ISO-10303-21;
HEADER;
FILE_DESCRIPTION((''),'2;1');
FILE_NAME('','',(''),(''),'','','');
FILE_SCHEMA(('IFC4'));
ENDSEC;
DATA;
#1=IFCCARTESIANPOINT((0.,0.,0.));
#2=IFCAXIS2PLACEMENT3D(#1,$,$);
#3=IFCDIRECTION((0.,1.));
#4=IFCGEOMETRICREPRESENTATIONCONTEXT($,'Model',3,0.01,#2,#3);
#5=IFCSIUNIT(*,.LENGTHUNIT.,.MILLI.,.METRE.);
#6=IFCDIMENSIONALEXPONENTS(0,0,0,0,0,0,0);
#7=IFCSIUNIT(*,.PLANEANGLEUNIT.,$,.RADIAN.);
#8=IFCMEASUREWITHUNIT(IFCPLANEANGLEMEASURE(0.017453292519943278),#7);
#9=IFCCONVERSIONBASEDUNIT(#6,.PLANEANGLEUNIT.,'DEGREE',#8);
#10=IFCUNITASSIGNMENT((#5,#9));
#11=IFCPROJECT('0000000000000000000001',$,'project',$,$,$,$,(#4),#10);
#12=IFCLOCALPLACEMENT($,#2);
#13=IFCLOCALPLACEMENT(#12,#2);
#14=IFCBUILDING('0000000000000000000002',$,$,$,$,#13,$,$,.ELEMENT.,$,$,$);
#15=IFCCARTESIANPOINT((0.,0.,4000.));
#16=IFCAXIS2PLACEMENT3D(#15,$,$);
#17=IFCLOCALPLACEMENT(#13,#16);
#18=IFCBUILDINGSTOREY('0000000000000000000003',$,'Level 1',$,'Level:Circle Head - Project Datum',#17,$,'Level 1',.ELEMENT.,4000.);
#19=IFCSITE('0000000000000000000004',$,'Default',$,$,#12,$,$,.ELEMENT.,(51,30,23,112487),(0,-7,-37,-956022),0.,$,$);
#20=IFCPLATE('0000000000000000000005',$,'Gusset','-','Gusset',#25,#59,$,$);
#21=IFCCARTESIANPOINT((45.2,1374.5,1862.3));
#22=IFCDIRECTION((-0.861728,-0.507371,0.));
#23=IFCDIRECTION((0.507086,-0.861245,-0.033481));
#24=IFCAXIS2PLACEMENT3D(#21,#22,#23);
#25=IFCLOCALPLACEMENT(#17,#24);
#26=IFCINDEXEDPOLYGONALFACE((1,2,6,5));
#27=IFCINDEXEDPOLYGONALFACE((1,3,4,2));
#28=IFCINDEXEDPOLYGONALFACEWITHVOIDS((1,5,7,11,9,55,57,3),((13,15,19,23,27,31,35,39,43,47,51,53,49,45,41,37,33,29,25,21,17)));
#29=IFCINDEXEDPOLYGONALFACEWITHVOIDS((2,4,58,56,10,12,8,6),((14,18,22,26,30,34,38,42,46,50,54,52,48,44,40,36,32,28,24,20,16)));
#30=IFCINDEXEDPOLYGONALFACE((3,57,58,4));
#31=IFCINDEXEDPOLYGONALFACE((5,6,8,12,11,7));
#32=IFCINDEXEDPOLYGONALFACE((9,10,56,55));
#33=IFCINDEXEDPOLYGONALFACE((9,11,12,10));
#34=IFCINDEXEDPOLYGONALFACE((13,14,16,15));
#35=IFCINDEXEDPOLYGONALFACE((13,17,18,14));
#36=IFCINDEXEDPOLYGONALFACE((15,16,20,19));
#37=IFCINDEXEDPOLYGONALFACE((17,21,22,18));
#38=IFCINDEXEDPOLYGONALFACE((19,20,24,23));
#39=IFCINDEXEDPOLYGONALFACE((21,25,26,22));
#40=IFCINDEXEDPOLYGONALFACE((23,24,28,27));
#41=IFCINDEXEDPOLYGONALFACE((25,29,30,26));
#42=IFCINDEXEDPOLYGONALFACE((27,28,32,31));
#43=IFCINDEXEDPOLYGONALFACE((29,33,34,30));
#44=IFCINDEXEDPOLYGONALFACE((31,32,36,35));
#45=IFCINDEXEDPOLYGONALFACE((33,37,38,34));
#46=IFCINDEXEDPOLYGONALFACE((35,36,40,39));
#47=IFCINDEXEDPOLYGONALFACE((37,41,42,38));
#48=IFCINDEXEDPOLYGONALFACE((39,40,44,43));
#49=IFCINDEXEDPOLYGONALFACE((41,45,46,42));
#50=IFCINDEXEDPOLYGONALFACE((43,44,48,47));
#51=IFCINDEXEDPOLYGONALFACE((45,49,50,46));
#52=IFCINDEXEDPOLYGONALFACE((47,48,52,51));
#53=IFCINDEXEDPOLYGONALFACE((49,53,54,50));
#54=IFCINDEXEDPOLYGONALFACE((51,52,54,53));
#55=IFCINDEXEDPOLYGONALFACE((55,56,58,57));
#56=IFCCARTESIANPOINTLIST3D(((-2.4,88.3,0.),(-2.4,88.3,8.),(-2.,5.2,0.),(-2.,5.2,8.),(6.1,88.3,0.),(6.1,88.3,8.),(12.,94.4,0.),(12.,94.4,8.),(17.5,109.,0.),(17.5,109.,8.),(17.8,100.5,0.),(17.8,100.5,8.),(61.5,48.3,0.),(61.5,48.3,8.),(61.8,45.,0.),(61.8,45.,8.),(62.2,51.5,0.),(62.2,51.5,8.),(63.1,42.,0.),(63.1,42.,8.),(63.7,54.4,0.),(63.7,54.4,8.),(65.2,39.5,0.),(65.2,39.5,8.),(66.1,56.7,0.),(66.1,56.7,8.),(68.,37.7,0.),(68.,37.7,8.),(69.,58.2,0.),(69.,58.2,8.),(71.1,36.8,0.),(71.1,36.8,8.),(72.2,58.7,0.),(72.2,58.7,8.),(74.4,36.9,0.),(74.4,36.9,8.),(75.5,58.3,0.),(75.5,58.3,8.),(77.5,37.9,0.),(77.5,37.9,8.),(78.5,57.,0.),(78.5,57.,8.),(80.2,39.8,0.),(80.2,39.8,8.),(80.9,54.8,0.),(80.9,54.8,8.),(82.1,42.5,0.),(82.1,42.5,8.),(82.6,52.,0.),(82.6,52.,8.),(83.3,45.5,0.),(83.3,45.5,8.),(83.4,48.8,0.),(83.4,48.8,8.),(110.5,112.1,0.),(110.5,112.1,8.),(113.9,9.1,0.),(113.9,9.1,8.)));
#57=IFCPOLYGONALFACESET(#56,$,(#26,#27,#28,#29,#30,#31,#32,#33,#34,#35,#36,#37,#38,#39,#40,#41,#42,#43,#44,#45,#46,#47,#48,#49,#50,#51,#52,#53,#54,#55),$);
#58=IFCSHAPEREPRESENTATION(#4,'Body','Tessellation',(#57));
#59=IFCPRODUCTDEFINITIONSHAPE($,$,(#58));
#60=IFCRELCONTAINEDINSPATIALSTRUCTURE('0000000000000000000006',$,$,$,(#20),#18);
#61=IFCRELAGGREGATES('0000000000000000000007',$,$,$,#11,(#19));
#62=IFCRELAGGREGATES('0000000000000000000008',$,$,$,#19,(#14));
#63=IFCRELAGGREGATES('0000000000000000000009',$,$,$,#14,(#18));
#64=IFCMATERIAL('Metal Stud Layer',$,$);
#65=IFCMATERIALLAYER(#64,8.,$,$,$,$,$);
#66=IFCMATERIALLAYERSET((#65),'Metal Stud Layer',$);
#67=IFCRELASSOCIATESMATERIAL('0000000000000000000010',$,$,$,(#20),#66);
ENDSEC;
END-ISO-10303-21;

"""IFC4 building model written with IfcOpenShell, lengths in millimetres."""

from ifc_helpers import new_model, entity, si_unit, converted_unit, point, direction, frame, frame_2d, origin, origin_with_axes, origin_2d_with_axis, place, context, project, spatial, polyline, circle_curve, line_curve, trimmed, segment, composite_curve, circle, outline, extrude, material, layer, layer_set, element, save


model = new_model("IFC4")

# Units and contexts
model_context = context("Model", 3, precision=0.01, world=origin(), true_north=direction((0.0, 1.0)))
ifc_project = project(units=[si_unit("LENGTHUNIT", "METRE", prefix="MILLI"), converted_unit("PLANEANGLEUNIT", "DEGREE", entity("IfcPlaneAngleMeasure", 0.017453292519943278), si_unit("PLANEANGLEUNIT", "RADIAN"), dimensions=[0, 0, 0, 0, 0, 0, 0])], contexts=[model_context])

# Site, building, storey
site_placement = place(None, origin())
site = spatial("IfcSite", under=ifc_project, at=site_placement, Name="Default", CompositionType="ELEMENT", RefLatitude=(51, 30, 23, 112487), RefLongitude=(0, -7, -37, -956022), RefElevation=0.0)
building_placement = place(site_placement, origin())
building = spatial("IfcBuilding", under=site, at=building_placement, CompositionType="ELEMENT")
storey_placement = place(building_placement, frame((0.0, 0.0, 4000.0)))
storey = spatial("IfcBuildingStorey", under=building, at=storey_placement, Name="Level 1", ObjectType="Level:Circle Head - Project Datum", LongName="Level 1", CompositionType="ELEMENT", Elevation=4000.0)

# Plate, openings
ifc_material_1 = material(Name="Metal Stud Layer")
ifc_layer_1 = layer(ifc_material_1, 8.0)
ifc_layer_set_1 = layer_set([ifc_layer_1], Name="Metal Stud Layer")
plate_1_placement = place(storey_placement, frame((45.2, 1374.5, 1862.3), z_axis=(-0.861728, -0.507371, 0.0), x_axis=(0.507086, -0.861245, -0.033481)))
plate_1 = element("IfcPlate", 1, at=plate_1_placement, inside=storey, material=ifc_layer_set_1, Name="Gusset", Description="-", ObjectType="Gusset", context=model_context, shape_type="SweptSolid", body=[
    extrude(outline(polyline([(-2.0, 5.2), (113.9, 9.1), (110.5, 112.1), (17.5, 109.0), (17.8, 100.5), (6.1, 88.3), (-2.4, 88.3), (-2.0, 5.2)])), origin_with_axes(), (0.0, 0.0, 1.0), 8.0),
])
opening_1_placement = place(plate_1_placement, origin_with_axes())
element("IfcOpeningElement", 2, at=opening_1_placement, cuts=plate_1, ObjectType="Opening", context=model_context, shape_type="SweptSolid", body=[
    extrude(outline(composite_curve([segment(trimmed(line_curve((17.8, 100.5), (-0.693597, -0.720363), 8.455359), [point((17.8, 100.5))], [point((12.0, 94.4))], True, "CARTESIAN"), True, "CONTINUOUS"), segment(trimmed(circle_curve(frame_2d((-2.4, 108.3), x_axis=(1.0, 0.0)), 20.0), [point((12.0, 94.4))], [point((17.5, 109.0))], True, "CARTESIAN"), True, "CONTINUOUS"), segment(trimmed(line_curve((17.5, 109.0), (0.033481, -0.999439), 8.455359), [point((17.5, 109.0))], [point((17.8, 100.5))], True, "CARTESIAN"), True, "CONTINUOUS")], self_intersect="UNKNOWN")), origin(), (0.0, 0.0, 1.0), 8.0),
])
opening_2_placement = place(plate_1_placement, origin_with_axes())
element("IfcOpeningElement", 3, at=opening_2_placement, cuts=plate_1, ObjectType="Opening", context=model_context, shape_type="SweptSolid", body=[
    extrude(outline(composite_curve([segment(trimmed(line_curve((6.1, 88.3), (-0.99999, -0.004369), 8.455359), [point((6.1, 88.3))], [point((-2.4, 88.3))], True, "CARTESIAN"), True, "CONTINUOUS"), segment(trimmed(circle_curve(frame_2d((-2.4, 108.3), x_axis=(1.0, 0.0)), 20.0), [point((-2.4, 88.3))], [point((12.0, 94.4))], True, "CARTESIAN"), True, "CONTINUOUS"), segment(trimmed(line_curve((12.0, 94.4), (-0.693597, -0.720363), 8.455359), [point((12.0, 94.4))], [point((6.1, 88.3))], True, "CARTESIAN"), True, "CONTINUOUS")], self_intersect="UNKNOWN")), origin(), (0.0, 0.0, 1.0), 8.0),
])
opening_3_placement = place(plate_1_placement, frame((72.5, 47.7, -0.5), z_axis=(0.0, 0.0, 1.0), x_axis=(0.8774, -0.47976, 0.0)))
element("IfcOpeningElement", 4, at=opening_3_placement, cuts=plate_1, ObjectType="Opening", context=model_context, shape_type="SweptSolid", body=[
    extrude(circle(Radius=11.0, at=origin_2d_with_axis()), origin(), (0.0, 0.0, 1.0), 9.0),
])

save(model, "model.ifc")
